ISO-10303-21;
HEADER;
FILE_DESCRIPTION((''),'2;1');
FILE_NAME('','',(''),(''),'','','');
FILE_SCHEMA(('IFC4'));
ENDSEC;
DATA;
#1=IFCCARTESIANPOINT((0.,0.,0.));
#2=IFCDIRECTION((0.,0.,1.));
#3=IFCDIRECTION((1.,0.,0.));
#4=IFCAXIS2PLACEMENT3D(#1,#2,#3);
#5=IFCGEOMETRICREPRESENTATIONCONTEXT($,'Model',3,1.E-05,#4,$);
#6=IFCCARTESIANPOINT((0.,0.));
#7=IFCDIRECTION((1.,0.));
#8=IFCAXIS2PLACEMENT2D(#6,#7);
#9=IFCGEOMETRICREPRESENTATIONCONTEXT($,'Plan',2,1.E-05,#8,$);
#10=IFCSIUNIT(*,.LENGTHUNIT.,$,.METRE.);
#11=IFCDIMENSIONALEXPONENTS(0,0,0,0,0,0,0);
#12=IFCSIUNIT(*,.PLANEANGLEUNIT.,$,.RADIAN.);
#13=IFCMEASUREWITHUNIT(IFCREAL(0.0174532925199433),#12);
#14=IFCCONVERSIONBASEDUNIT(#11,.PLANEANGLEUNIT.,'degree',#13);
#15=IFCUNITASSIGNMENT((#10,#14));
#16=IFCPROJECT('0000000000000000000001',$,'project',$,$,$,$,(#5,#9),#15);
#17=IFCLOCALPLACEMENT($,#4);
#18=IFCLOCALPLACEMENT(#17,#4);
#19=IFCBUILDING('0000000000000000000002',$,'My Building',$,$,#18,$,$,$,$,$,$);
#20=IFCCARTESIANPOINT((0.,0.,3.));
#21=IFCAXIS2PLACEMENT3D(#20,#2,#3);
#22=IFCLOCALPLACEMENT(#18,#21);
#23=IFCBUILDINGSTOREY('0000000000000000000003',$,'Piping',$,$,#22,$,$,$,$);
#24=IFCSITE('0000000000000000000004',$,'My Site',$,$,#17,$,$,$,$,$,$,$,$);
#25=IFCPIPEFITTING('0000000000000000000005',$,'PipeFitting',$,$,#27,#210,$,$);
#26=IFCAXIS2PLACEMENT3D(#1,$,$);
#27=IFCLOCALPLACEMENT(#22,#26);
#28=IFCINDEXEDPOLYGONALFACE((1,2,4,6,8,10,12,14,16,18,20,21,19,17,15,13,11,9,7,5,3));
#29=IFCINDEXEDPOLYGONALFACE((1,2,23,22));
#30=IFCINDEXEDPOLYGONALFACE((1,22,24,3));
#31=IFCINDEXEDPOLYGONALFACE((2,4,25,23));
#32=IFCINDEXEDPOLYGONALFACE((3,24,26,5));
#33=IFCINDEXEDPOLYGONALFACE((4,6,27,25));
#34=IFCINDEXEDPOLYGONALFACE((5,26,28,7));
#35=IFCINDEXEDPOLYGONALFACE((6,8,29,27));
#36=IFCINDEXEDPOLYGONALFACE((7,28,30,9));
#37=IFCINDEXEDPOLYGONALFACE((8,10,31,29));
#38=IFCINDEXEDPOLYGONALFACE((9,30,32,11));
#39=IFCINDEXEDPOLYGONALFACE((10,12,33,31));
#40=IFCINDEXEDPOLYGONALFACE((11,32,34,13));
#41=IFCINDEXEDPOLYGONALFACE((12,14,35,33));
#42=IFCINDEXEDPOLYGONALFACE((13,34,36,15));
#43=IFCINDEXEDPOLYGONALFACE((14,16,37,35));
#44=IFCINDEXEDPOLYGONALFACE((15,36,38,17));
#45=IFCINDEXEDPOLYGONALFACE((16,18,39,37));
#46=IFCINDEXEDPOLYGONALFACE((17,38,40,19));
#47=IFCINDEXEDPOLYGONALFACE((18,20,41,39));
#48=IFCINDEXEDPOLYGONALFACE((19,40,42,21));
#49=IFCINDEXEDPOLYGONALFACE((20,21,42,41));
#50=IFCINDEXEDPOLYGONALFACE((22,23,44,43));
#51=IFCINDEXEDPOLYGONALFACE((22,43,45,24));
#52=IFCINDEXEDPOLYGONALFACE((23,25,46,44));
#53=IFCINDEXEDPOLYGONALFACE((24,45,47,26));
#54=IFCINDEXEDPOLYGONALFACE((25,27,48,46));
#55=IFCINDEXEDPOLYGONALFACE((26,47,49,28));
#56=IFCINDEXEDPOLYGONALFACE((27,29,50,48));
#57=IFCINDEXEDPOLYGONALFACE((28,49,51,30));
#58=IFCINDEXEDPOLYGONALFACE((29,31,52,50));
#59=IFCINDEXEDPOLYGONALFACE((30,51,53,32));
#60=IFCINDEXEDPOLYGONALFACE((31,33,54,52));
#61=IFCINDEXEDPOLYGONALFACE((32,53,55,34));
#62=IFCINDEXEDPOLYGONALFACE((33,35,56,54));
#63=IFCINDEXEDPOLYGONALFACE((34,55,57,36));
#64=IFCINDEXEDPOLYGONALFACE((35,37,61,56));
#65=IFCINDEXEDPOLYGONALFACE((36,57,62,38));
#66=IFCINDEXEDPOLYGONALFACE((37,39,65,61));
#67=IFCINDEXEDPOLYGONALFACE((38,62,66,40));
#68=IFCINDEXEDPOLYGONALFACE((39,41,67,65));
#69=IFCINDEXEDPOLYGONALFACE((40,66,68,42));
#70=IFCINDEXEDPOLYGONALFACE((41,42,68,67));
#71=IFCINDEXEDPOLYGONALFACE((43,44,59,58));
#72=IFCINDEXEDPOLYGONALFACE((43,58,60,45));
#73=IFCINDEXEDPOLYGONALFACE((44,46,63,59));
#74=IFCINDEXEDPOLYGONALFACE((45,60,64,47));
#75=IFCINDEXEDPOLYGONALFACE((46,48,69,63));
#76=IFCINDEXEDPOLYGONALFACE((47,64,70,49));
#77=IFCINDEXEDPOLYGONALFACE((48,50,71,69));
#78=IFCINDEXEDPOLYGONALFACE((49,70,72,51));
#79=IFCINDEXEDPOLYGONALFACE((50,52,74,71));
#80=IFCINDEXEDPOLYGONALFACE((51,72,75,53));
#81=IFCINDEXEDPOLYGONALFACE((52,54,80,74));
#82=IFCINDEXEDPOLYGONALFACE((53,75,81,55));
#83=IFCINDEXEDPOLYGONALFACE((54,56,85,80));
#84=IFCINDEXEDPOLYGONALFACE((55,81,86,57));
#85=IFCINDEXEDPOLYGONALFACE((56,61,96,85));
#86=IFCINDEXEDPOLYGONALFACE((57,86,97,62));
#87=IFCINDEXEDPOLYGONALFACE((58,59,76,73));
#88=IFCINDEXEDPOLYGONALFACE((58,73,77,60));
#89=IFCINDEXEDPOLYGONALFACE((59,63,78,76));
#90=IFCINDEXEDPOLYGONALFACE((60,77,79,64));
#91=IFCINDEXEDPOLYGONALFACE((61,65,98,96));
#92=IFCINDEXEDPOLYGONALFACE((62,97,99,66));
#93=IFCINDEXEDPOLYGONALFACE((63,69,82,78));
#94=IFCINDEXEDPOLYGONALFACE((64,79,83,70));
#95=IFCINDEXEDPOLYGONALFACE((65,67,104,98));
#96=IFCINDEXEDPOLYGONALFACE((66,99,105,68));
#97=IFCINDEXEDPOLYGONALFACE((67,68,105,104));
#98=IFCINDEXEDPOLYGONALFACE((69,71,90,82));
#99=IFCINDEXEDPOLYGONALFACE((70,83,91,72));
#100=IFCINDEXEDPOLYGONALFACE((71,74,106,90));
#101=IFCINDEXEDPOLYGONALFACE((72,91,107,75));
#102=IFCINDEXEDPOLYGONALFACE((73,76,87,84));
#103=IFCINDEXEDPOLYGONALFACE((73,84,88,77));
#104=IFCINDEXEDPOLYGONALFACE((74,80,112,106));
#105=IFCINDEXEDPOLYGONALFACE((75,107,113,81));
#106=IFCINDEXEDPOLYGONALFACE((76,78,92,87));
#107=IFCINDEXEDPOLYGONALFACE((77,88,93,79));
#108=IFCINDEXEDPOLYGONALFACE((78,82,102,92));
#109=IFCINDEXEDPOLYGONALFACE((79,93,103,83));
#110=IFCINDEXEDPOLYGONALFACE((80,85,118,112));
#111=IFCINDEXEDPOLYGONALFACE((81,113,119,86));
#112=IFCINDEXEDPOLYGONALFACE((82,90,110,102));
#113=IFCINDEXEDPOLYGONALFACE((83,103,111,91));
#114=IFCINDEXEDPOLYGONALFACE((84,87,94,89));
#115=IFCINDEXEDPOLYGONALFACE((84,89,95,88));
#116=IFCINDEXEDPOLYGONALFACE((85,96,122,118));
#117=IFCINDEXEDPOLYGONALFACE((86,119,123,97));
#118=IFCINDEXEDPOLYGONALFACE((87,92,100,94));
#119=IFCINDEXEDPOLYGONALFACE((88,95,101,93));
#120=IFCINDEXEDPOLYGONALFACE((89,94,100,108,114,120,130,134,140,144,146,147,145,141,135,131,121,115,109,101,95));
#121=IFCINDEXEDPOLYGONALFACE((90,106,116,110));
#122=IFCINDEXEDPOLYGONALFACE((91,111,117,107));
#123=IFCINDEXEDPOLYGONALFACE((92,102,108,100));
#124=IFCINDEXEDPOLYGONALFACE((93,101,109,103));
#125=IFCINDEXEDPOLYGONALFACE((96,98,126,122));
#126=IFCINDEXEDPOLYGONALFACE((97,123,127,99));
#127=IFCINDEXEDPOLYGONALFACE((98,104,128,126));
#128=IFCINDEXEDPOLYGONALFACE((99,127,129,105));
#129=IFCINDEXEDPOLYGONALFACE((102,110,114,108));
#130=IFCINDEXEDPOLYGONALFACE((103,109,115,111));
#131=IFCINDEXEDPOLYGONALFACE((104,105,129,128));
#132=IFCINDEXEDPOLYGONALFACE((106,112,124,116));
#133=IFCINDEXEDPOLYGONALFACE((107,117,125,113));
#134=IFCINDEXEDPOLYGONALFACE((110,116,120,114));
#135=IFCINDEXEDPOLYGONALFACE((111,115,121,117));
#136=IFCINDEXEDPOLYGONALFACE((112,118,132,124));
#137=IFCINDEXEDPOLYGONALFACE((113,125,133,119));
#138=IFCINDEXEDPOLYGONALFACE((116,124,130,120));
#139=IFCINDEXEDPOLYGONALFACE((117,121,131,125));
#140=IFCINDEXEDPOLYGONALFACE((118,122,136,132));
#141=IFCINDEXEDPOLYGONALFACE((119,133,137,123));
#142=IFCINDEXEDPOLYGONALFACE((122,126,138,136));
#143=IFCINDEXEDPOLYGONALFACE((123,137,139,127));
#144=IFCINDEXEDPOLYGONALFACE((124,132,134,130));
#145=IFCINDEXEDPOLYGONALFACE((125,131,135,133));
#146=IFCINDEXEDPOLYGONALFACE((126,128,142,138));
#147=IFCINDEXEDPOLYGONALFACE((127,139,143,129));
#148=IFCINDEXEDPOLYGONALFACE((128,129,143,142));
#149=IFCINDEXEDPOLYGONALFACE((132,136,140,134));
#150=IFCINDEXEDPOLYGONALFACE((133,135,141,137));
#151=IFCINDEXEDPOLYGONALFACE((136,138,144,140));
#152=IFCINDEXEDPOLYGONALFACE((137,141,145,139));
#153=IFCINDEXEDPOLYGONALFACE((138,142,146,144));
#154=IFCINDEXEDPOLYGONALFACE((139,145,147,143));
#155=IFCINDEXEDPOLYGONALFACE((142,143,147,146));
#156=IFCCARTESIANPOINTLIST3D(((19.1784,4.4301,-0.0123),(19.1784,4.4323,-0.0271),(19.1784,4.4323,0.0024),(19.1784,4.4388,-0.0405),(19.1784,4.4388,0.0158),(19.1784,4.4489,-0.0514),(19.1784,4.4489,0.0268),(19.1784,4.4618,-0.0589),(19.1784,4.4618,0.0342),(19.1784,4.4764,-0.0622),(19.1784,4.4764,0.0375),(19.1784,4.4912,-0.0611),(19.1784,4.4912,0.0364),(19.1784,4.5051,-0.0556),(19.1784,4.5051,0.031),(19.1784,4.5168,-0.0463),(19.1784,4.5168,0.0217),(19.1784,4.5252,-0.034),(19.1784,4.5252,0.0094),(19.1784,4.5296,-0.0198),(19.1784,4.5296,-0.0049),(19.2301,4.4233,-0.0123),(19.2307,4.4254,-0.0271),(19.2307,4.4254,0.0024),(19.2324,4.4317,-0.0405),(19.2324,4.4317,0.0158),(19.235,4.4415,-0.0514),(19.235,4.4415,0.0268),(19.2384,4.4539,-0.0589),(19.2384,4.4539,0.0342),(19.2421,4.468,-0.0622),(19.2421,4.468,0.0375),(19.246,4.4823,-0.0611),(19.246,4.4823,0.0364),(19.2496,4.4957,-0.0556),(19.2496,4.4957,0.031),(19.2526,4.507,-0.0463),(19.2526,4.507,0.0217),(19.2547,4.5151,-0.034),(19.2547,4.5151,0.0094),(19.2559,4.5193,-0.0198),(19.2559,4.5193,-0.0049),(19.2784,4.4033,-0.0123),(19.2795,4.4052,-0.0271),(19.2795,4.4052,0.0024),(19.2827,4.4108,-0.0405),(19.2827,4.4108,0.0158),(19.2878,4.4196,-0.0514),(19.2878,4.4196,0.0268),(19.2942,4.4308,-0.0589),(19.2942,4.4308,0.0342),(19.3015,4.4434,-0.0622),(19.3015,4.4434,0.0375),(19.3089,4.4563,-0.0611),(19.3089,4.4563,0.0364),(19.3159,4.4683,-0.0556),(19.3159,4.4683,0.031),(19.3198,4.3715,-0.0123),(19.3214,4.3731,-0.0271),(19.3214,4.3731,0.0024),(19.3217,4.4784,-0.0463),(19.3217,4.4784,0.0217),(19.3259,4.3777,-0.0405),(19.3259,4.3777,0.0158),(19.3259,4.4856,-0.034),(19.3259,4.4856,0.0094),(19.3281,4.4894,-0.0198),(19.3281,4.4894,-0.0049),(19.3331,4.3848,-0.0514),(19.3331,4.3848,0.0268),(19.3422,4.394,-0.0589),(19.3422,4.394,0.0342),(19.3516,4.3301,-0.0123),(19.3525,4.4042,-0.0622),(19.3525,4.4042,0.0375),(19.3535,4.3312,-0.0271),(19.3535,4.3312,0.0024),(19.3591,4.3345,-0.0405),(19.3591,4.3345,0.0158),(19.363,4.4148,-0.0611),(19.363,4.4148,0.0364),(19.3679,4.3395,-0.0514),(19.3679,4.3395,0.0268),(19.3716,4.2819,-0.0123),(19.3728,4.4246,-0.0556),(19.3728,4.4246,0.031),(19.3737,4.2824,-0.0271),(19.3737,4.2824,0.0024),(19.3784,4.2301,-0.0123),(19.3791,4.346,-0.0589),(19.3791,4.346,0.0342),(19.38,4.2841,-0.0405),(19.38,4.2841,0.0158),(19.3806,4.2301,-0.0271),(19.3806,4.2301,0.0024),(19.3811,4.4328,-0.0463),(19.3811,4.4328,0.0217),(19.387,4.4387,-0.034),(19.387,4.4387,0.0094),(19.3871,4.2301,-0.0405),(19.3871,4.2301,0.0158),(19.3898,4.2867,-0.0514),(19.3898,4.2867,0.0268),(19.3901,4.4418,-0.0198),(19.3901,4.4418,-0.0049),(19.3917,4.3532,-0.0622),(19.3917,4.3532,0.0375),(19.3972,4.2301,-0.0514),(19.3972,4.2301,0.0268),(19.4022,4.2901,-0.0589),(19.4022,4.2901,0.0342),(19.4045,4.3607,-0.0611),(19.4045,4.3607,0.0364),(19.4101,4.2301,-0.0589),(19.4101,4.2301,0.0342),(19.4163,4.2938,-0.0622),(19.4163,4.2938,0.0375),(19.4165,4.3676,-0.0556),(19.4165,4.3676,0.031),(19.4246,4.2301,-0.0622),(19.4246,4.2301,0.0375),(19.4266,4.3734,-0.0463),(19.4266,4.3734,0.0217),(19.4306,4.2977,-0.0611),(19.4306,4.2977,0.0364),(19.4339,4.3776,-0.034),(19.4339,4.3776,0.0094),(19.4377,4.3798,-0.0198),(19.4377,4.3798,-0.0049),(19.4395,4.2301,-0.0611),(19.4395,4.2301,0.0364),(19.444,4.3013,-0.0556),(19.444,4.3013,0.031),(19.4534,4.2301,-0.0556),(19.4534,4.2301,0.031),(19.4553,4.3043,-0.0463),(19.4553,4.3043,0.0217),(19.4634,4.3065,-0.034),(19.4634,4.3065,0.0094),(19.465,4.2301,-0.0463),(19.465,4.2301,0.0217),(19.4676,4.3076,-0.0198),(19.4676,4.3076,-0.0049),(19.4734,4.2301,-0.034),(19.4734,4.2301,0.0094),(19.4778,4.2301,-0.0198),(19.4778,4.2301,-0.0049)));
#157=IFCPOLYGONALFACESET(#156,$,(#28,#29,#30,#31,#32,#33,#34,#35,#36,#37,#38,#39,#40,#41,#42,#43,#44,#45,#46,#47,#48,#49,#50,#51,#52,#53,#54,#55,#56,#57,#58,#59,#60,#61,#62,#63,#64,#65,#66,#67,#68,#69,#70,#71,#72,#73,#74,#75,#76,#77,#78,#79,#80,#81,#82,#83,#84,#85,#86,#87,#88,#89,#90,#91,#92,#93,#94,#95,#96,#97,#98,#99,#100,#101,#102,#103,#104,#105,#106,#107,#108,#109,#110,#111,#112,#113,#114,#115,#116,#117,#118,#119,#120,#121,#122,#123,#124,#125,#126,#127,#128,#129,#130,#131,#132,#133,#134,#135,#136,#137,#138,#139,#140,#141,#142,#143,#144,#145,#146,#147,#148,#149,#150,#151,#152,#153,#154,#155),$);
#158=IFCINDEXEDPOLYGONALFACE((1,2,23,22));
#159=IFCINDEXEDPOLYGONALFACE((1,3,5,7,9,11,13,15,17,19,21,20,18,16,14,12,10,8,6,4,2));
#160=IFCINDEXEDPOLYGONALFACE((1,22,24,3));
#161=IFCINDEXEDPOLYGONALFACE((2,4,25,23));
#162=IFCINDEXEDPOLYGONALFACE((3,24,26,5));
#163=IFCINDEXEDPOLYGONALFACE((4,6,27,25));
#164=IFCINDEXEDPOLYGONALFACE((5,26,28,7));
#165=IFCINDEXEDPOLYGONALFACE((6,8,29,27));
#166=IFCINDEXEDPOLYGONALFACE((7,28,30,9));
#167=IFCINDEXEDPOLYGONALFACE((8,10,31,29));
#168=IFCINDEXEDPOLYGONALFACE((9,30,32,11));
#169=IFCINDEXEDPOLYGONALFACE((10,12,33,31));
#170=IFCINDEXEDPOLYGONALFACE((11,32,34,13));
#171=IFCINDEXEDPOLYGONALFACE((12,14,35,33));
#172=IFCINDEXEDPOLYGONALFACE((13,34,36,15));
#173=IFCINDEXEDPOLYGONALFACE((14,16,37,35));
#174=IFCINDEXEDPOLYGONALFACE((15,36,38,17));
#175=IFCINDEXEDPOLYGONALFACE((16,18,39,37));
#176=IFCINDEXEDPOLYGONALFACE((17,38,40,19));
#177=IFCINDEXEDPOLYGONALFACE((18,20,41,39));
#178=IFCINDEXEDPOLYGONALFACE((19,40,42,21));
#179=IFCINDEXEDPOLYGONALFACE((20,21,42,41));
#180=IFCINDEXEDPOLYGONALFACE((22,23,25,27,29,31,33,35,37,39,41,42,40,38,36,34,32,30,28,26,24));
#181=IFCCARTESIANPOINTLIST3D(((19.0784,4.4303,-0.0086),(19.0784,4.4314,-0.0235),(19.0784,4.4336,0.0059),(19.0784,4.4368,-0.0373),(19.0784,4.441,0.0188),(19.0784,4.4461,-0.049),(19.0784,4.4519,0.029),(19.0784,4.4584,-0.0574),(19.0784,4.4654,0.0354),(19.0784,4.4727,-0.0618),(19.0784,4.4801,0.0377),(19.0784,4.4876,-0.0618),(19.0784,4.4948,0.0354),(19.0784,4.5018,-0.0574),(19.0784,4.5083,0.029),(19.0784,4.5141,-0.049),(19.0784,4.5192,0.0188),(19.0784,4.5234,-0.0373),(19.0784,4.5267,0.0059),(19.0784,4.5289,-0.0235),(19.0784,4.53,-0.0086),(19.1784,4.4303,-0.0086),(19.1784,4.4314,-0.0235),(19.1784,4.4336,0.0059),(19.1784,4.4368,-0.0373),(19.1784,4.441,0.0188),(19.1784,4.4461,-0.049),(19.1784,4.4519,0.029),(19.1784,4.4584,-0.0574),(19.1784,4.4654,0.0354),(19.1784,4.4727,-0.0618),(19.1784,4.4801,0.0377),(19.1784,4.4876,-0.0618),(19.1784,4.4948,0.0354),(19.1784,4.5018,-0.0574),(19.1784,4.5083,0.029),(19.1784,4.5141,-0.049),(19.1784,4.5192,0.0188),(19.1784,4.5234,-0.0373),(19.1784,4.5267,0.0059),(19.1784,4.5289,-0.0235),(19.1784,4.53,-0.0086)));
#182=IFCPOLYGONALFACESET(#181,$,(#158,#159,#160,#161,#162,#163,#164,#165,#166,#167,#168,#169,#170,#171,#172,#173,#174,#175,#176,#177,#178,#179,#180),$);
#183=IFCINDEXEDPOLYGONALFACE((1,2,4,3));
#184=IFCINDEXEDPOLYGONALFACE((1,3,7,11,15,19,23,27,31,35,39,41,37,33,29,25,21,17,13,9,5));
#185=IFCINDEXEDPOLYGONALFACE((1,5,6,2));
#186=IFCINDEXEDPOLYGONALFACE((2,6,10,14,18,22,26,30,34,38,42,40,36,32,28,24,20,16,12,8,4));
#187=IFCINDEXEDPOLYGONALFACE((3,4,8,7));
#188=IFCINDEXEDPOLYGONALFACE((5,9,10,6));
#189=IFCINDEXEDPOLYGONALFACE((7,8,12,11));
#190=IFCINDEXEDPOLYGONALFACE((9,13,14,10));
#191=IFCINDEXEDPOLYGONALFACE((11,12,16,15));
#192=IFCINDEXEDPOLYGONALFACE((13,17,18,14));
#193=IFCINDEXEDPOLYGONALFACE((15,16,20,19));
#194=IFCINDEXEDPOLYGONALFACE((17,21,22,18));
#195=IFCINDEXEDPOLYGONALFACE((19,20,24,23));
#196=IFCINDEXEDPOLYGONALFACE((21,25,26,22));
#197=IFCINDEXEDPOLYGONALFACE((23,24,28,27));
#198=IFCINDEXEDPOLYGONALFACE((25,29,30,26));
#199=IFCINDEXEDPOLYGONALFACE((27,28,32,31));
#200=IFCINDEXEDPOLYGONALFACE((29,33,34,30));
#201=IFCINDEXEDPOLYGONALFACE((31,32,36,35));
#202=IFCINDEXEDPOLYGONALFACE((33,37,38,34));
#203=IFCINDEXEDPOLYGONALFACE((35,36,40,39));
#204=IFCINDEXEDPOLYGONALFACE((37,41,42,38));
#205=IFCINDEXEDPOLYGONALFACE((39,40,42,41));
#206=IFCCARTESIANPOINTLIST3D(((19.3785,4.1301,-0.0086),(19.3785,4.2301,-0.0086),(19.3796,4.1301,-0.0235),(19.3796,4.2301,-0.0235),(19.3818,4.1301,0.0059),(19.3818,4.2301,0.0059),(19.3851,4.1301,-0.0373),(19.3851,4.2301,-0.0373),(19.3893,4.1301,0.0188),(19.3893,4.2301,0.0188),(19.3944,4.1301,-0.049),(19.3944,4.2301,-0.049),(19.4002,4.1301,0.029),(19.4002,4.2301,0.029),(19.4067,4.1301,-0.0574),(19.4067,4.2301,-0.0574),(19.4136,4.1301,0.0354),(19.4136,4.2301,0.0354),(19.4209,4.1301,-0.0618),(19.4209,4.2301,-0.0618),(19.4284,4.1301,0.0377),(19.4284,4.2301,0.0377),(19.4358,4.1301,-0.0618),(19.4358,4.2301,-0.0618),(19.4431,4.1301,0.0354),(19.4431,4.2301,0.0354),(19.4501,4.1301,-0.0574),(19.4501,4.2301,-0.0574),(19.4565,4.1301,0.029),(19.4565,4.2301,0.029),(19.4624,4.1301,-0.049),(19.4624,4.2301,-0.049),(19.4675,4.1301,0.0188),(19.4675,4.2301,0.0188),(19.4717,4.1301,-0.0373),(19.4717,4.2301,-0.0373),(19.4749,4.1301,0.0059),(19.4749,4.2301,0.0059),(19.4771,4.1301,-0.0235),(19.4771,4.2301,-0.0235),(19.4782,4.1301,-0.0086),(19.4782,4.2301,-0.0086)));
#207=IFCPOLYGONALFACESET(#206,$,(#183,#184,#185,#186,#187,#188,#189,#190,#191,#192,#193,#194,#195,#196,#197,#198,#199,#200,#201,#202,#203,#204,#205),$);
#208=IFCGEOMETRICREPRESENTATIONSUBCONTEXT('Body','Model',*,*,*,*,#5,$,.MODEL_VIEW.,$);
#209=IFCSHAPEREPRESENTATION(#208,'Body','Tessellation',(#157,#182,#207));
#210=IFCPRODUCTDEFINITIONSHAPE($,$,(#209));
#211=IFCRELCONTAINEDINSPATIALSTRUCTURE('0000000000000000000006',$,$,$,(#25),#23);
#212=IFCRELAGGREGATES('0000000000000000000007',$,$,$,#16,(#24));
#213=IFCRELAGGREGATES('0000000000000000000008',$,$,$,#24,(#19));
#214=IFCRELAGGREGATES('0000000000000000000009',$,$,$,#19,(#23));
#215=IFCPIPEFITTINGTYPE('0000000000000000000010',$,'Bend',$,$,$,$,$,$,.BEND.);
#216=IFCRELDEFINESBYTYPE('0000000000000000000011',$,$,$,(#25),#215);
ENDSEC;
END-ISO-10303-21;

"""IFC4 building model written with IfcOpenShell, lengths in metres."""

from ifc_helpers import new_model, entity, si_unit, converted_unit, frame, origin_with_axes, origin_2d_with_axis, place, context, subcontext, project, spatial, circle, extrude, source, transform, mapped, type_object, type_shapes, element, save


model = new_model("IFC4")

# Units and contexts
model_context = context("Model", 3, precision=1e-05, world=origin_with_axes())
plan_context = context("Plan", 2, precision=1e-05, world=origin_2d_with_axis())
body_context = subcontext(model_context, "Body", "Model", "MODEL_VIEW")
ifc_project = project(units=[si_unit("LENGTHUNIT", "METRE"), converted_unit("PLANEANGLEUNIT", "degree", entity("IfcReal", 0.0174532925199433), si_unit("PLANEANGLEUNIT", "RADIAN"), dimensions=[0, 0, 0, 0, 0, 0, 0])], contexts=[model_context, plan_context])

# Site, building, storey
site_placement = place(None, origin_with_axes())
site = spatial("IfcSite", under=ifc_project, at=site_placement, Name="My Site")
building_placement = place(site_placement, origin_with_axes())
building = spatial("IfcBuilding", under=site, at=building_placement, Name="My Building")
storey_placement = place(building_placement, frame((0.0, 0.0, 3.0), z_axis=(0.0, 0.0, 1.0), x_axis=(1.0, 0.0, 0.0)))
storey = spatial("IfcBuildingStorey", under=building, at=storey_placement, Name="Piping")

# Pipe fitting
pipe_fitting_type = type_object("IfcPipeFittingType", Name="Bend", PredefinedType="BEND")
shared_shape = source(origin_with_axes(), body_context, "Body", "SolidModel", [
    entity("IfcSweptDiskSolid", entity("IfcIndexedPolyCurve", entity("IfcCartesianPointList3D", [[0.0, 0.0, -0.1], [0.0, -0.0732, -0.2768], [0.0, -0.25, -0.35]]), [entity("IfcArcIndex", [1, 2, 3])]), 0.05),
    extrude(circle(Radius=0.05), origin_with_axes(), (0.0, 0.0, -1.0), 0.1),
    extrude(circle(Radius=0.05), frame((0.0, -0.25, -0.35), z_axis=(0.0, -1.0, 0.0), x_axis=(1.0, 0.0, 0.0)), (0.0, 0.0, 1.0), 0.1),
])
type_shapes(pipe_fitting_type, [shared_shape])
for number, where, z_axis, x_axis, name in (
    (1, (19.0784, 4.4801, -0.0123), (-1.0, 0.0, 0.0), (0.0, 0.0, 1.0), "PipeFitting"),
):
    element("IfcPipeFitting", number, at=place(storey_placement, frame(where, z_axis=z_axis, x_axis=x_axis)), inside=storey, type_object=pipe_fitting_type, Name=name, context=body_context, shape_type="MappedRepresentation", body=[
        mapped(shared_shape, transform((0.0, 0.0, 0.0), x_axis=(1.0, 0.0, 0.0), y_axis=(0.0, 1.0, 0.0), z_axis=(0.0, 0.0, 1.0), scale=1.0)),
    ])

save(model, "model.ifc")
